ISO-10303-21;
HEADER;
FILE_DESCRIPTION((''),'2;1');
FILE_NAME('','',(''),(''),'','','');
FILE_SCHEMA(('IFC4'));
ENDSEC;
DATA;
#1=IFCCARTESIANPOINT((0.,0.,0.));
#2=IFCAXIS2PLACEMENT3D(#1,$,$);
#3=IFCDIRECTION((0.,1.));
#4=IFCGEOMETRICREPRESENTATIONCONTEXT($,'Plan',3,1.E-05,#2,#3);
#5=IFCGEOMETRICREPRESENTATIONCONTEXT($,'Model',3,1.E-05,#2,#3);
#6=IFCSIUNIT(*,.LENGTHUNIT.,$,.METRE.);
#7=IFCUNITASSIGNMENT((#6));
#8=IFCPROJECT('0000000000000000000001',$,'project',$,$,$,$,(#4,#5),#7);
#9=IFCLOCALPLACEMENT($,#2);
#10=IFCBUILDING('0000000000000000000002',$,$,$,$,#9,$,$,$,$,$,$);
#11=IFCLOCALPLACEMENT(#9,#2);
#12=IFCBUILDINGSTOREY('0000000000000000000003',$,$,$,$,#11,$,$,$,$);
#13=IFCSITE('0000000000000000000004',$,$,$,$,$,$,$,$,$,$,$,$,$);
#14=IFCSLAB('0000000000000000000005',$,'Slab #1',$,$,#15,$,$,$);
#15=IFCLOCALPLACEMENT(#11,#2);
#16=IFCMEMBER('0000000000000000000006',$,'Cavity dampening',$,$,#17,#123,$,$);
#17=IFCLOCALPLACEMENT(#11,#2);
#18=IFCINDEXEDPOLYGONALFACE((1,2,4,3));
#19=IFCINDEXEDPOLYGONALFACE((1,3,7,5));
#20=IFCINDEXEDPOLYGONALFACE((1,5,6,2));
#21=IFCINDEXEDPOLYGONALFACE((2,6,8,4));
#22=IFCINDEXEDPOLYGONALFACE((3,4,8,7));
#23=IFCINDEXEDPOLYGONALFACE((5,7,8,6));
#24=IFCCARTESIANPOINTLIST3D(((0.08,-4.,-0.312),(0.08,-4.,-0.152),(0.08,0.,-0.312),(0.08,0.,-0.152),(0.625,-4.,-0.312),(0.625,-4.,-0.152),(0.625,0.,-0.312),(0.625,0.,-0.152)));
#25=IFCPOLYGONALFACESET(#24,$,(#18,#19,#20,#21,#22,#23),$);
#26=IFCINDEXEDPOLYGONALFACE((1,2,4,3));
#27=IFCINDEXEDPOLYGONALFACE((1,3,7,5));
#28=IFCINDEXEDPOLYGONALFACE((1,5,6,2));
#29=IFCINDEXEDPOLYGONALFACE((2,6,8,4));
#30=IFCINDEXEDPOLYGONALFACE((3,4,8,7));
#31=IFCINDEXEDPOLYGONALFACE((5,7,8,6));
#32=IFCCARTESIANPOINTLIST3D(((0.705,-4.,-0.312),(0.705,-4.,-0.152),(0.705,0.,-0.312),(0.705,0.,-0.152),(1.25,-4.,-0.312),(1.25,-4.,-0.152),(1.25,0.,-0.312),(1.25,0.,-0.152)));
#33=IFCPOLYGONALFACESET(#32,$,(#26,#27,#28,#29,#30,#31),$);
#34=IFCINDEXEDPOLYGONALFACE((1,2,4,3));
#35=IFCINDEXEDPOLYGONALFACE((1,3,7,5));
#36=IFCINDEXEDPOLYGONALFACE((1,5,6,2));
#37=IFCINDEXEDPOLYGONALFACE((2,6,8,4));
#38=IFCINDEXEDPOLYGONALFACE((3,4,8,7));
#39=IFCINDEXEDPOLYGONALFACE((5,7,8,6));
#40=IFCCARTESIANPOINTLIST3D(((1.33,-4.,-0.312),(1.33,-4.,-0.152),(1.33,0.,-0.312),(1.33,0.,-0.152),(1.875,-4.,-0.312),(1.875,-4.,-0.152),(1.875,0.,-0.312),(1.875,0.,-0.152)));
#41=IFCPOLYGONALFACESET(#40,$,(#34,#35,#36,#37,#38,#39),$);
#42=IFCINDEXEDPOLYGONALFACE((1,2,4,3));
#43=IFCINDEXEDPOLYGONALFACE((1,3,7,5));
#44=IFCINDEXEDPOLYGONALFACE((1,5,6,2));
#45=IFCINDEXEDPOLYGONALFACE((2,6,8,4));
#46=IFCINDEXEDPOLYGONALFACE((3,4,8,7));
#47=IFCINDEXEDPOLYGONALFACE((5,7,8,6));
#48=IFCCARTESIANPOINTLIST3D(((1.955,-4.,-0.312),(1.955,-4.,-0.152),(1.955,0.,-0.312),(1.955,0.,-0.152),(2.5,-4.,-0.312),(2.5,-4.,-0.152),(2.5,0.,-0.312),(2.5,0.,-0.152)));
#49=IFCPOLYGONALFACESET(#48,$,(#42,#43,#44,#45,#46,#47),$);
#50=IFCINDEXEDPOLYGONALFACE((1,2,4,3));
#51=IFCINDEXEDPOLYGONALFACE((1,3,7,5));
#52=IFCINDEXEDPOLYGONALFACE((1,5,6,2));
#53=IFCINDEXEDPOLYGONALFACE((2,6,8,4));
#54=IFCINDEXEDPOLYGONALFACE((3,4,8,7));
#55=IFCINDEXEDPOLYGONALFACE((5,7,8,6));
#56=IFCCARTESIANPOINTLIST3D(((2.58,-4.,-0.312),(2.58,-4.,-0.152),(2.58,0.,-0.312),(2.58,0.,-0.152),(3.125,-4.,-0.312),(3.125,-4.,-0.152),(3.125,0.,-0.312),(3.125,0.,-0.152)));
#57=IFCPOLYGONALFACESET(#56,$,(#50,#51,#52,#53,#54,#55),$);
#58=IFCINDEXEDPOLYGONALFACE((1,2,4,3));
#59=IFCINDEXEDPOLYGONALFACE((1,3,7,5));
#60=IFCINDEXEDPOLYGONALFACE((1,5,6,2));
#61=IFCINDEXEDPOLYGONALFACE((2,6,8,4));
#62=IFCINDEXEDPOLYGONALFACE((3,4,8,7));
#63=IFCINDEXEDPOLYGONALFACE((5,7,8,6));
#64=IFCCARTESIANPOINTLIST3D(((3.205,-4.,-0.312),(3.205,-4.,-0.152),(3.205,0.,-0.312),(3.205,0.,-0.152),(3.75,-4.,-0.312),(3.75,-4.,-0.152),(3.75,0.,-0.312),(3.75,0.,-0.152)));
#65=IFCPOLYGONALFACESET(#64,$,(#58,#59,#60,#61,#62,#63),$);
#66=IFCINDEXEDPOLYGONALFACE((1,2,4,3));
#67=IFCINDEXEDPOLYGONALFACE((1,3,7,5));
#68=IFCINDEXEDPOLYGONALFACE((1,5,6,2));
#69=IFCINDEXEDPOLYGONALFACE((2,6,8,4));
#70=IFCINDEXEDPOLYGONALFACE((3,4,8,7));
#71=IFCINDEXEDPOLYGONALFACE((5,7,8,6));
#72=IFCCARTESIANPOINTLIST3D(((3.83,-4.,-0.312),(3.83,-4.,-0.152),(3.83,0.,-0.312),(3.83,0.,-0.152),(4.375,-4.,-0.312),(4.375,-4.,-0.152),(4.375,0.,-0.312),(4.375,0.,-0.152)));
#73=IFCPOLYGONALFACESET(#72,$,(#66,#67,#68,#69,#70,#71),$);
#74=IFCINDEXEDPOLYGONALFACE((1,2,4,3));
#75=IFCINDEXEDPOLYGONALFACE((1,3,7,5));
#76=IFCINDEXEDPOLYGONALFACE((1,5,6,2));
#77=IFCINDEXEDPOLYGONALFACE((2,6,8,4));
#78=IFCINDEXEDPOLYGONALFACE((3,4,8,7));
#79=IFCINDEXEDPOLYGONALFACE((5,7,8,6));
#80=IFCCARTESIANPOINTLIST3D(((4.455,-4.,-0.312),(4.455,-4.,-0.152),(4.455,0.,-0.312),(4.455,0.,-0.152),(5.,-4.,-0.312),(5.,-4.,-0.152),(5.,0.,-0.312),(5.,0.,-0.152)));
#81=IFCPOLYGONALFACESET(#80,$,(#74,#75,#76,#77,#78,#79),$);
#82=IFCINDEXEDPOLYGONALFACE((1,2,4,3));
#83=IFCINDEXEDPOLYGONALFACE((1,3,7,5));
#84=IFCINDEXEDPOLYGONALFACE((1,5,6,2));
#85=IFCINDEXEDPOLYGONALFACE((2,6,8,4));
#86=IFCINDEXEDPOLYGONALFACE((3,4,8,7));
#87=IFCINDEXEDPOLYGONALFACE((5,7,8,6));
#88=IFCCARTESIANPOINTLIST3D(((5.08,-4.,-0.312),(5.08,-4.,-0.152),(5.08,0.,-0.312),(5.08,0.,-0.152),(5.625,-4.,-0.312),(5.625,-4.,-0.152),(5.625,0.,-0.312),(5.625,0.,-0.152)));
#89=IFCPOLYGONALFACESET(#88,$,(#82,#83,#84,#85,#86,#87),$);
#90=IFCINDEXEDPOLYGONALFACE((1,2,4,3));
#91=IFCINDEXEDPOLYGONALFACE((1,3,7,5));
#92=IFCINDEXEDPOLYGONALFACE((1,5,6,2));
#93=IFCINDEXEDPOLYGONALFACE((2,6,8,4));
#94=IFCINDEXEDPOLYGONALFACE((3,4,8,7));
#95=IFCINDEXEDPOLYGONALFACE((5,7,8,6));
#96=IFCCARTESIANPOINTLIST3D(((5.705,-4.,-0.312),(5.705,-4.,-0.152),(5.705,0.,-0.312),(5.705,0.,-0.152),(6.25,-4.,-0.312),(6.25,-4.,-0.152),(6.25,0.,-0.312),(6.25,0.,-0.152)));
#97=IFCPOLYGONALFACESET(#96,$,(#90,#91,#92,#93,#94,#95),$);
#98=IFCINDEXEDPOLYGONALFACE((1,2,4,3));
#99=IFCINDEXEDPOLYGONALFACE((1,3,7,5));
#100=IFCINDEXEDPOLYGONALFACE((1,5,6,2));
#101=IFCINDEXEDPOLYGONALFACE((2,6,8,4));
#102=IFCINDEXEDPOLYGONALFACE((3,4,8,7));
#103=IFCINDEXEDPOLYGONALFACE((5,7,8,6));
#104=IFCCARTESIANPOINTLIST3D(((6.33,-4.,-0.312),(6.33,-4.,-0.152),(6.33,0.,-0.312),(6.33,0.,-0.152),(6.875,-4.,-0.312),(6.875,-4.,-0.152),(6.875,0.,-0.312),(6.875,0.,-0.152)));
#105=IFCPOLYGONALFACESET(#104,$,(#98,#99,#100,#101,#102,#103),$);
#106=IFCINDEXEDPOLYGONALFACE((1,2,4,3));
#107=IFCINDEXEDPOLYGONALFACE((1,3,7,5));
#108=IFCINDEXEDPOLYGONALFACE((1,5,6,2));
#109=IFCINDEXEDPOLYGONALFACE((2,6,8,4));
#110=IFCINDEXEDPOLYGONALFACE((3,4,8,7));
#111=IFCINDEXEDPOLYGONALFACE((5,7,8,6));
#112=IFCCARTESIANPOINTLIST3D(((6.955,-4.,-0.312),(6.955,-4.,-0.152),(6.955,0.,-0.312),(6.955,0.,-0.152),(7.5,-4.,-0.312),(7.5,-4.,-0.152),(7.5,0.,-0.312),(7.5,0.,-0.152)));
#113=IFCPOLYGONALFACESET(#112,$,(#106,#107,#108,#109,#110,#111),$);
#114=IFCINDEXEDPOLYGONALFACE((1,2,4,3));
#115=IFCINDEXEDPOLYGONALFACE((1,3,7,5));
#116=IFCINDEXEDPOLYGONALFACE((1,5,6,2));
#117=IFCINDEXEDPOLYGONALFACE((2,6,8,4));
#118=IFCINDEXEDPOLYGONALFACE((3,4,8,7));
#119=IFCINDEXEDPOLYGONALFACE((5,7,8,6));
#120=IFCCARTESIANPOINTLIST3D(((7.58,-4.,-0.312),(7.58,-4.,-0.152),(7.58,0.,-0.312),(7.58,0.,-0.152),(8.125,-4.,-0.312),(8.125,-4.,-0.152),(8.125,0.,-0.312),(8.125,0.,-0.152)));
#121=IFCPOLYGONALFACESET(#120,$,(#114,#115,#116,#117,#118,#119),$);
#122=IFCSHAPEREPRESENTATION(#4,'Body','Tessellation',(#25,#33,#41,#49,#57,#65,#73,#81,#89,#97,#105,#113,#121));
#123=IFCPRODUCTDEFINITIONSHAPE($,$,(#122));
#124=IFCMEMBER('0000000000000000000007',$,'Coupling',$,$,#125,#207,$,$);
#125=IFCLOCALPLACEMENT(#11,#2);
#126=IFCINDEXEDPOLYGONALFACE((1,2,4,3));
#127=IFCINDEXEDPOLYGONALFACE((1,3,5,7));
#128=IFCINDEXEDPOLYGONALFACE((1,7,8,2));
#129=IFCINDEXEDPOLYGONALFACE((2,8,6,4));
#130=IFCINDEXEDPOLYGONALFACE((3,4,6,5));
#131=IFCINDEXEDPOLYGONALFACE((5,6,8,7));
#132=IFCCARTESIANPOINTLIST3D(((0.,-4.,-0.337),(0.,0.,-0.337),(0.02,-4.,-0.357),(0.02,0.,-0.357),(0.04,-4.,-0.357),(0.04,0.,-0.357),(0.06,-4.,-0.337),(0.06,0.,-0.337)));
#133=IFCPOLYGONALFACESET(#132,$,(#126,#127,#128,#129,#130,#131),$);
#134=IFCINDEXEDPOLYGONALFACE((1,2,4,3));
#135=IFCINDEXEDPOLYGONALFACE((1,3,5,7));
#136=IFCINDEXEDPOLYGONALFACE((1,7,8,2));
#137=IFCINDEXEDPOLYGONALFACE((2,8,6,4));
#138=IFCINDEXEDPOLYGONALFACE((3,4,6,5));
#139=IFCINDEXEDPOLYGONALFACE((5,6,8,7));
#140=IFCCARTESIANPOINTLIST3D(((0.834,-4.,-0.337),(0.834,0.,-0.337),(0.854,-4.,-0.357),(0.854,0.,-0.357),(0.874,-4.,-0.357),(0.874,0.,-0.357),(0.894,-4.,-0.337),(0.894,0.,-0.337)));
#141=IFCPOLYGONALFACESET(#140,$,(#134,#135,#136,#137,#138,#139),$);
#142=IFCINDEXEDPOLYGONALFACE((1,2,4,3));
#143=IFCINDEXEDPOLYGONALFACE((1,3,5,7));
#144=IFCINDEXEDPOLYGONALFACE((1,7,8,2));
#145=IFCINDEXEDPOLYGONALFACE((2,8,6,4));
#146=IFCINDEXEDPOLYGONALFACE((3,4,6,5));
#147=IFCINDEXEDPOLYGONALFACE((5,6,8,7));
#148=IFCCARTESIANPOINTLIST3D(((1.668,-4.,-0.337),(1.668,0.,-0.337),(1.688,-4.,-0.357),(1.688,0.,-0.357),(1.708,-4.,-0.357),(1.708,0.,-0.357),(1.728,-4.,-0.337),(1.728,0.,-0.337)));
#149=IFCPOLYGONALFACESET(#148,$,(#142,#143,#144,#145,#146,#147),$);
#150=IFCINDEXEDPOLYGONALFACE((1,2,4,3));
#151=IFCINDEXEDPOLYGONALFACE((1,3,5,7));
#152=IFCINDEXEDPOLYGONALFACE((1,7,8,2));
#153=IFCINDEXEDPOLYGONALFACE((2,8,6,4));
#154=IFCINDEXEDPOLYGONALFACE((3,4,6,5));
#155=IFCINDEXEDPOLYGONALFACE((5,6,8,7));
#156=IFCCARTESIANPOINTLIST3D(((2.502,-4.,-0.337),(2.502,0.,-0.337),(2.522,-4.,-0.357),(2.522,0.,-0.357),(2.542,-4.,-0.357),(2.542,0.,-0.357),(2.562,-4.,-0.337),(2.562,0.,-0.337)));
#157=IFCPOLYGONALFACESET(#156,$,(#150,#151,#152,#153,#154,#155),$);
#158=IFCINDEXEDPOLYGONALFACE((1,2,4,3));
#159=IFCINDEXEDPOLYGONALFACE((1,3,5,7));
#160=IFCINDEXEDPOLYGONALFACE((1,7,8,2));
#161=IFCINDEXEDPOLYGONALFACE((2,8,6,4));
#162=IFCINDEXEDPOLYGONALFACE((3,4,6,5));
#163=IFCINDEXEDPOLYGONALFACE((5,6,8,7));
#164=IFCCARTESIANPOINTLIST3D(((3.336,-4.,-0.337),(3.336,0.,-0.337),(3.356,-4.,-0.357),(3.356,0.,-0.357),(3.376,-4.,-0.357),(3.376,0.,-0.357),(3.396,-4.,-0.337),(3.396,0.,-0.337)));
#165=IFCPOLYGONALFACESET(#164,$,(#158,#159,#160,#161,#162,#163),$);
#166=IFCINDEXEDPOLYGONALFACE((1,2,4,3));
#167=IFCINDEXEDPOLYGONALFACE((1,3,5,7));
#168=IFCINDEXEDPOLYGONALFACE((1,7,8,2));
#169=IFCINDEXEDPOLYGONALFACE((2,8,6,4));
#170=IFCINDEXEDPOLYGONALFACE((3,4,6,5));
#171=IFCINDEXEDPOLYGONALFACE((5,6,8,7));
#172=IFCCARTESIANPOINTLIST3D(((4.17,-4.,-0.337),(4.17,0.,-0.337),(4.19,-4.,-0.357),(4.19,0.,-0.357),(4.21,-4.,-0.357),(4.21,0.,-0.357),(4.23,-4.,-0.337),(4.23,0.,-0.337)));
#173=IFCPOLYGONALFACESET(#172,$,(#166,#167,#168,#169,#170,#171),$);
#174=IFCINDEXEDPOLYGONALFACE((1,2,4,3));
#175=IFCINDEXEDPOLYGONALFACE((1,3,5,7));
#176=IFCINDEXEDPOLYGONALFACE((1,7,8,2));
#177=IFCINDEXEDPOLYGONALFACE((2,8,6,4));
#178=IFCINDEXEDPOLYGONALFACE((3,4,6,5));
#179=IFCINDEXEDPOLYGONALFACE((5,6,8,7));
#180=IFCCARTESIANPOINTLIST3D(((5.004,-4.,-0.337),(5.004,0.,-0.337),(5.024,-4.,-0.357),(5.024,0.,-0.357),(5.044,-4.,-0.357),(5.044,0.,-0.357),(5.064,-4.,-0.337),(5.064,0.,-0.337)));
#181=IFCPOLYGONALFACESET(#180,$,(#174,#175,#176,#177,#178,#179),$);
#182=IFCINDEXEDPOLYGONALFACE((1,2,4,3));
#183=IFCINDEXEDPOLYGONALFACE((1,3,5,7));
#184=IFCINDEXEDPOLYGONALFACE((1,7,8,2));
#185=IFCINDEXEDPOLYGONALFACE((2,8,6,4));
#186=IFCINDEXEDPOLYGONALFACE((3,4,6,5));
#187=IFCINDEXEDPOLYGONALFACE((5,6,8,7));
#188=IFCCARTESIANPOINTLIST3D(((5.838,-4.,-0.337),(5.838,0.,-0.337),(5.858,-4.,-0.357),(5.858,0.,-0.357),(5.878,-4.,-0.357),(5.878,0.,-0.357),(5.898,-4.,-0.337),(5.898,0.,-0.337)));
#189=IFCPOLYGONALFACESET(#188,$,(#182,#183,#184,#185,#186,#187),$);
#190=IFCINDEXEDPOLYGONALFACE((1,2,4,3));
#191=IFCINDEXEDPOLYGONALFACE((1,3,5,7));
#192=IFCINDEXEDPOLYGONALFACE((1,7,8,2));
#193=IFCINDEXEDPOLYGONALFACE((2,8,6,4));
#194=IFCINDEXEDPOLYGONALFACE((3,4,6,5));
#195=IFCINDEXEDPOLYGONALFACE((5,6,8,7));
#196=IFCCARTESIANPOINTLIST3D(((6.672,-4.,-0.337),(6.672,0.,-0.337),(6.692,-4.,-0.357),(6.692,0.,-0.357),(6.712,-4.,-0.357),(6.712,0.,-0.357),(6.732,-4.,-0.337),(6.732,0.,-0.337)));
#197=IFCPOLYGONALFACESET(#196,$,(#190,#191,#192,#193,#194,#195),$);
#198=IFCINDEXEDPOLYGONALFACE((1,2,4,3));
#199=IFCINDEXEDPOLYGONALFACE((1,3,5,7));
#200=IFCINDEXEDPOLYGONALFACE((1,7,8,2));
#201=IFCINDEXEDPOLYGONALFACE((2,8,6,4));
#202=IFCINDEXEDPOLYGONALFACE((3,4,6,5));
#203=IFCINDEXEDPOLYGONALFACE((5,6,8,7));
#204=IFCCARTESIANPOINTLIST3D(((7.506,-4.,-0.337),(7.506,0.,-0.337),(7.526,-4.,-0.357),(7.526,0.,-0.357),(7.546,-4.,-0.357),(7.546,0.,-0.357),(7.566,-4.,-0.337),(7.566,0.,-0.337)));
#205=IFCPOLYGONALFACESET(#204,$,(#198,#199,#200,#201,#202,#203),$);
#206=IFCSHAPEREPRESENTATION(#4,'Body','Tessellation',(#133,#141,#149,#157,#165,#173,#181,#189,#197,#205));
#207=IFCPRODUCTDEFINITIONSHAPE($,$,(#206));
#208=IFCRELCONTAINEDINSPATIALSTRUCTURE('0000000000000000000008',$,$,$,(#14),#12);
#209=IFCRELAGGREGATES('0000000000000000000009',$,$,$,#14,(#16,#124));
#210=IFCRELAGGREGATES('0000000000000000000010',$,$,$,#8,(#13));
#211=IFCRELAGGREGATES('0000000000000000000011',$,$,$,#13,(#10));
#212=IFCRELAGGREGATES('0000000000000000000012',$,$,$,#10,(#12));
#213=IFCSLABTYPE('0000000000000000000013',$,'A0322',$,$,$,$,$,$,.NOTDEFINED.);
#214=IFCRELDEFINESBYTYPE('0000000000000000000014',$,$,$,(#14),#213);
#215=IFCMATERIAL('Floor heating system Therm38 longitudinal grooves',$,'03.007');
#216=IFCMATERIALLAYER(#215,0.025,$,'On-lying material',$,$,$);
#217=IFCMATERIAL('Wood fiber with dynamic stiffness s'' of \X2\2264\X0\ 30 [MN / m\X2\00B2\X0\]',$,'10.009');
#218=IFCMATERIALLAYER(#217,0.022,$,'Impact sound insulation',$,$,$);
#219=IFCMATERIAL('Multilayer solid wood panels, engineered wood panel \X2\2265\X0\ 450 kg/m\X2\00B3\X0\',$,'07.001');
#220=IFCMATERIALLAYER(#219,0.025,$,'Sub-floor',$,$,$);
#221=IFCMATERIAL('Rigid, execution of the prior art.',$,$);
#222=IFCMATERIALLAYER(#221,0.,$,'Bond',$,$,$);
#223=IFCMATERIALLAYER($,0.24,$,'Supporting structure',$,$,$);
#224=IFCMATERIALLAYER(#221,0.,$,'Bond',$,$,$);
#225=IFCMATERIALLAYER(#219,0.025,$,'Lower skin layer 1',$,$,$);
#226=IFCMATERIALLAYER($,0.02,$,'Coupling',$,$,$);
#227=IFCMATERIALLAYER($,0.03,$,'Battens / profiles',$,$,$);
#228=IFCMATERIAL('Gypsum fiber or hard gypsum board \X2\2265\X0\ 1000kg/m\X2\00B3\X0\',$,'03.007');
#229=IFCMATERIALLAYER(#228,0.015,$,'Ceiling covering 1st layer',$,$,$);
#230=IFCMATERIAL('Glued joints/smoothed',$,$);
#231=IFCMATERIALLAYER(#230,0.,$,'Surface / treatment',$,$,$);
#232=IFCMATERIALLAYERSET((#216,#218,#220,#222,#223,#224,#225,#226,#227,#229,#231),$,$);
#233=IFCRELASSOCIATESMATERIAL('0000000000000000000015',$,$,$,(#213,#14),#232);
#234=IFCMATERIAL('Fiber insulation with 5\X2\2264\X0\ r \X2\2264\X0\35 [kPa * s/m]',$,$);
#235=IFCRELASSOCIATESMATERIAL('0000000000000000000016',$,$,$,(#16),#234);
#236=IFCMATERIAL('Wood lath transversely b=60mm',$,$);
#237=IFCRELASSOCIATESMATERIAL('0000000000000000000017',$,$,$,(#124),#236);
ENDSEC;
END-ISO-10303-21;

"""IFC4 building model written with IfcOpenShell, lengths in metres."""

from ifc_helpers import new_model, si_unit, direction, frame, frame_2d, origin, place, context, project, spatial, polyline, rectangle, outline, extrude, material, layer, layer_set, type_object, element, aggregate, save


model = new_model("IFC4")

# Units and contexts
plan_context = context("Plan", 3, precision=1e-05, world=origin(), true_north=direction((0.0, 1.0)))
model_context = context("Model", 3, precision=1e-05, world=origin(), true_north=direction((0.0, 1.0)))
ifc_project = project(units=[si_unit("LENGTHUNIT", "METRE")], contexts=[plan_context, model_context])

# Site, building, storey
site = spatial("IfcSite", under=ifc_project)
building_placement = place(None, origin())
building = spatial("IfcBuilding", under=site, at=building_placement)
storey_placement = place(building_placement, origin())
storey = spatial("IfcBuildingStorey", under=building, at=storey_placement)

# Slab, members
ifc_material_1 = material(Name="Floor heating system Therm38 longitudinal grooves", Category="03.007")
ifc_layer_1 = layer(ifc_material_1, 0.025, Name="On-lying material")
ifc_material_2 = material(Name="Wood fiber with dynamic stiffness s' of ≤ 30 [MN / m²]", Category="10.009")
ifc_layer_2 = layer(ifc_material_2, 0.022, Name="Impact sound insulation")
ifc_material_3 = material(Name="Multilayer solid wood panels, engineered wood panel ≥ 450 kg/m³", Category="07.001")
ifc_layer_3 = layer(ifc_material_3, 0.025, Name="Sub-floor")
ifc_material_4 = material(Name="Rigid, execution of the prior art.")
ifc_layer_4 = layer(ifc_material_4, 0.0, Name="Bond")
ifc_layer_5 = layer(None, 0.24, Name="Supporting structure")
ifc_layer_6 = layer(ifc_material_4, 0.0, Name="Bond")
ifc_layer_7 = layer(ifc_material_3, 0.025, Name="Lower skin layer 1")
ifc_layer_8 = layer(None, 0.02, Name="Coupling")
ifc_layer_9 = layer(None, 0.03, Name="Battens / profiles")
ifc_material_5 = material(Name="Gypsum fiber or hard gypsum board ≥ 1000kg/m³", Category="03.007")
ifc_layer_10 = layer(ifc_material_5, 0.015, Name="Ceiling covering 1st layer")
ifc_material_6 = material(Name="Glued joints/smoothed")
ifc_layer_11 = layer(ifc_material_6, 0.0, Name="Surface / treatment")
ifc_layer_set = layer_set([ifc_layer_1, ifc_layer_2, ifc_layer_3, ifc_layer_4, ifc_layer_5, ifc_layer_6, ifc_layer_7, ifc_layer_8, ifc_layer_9, ifc_layer_10, ifc_layer_11])
slab_type = type_object("IfcSlabType", Name="A0322", PredefinedType="NOTDEFINED", material=ifc_layer_set)
slab_placement = place(None, frame((0.0, 0.0, 0.0), z_axis=(0.0, 0.0, -1.0), x_axis=(1.0, 0.0, 0.0)))
slab = element("IfcSlab", 1, at=slab_placement, inside=storey, type_object=slab_type, material=ifc_layer_set, Name="Slab #1")
ifc_material_7 = material(Name="Fiber insulation with 5≤ r ≤35 [kPa * s/m]")
member_1_placement = place(slab_placement, origin())
member_1 = element("IfcMember", 2, at=member_1_placement, material=ifc_material_7, Name="Cavity dampening", context=plan_context, shape_type="SweptSolid", body=[
    extrude(rectangle(XDim=0.545, YDim=0.16, at=frame_2d((0.2725, 0.08), x_axis=(1.0, 0.0))), frame((0.08, 4.0, 0.152), z_axis=(0.0, -1.0, 0.0), x_axis=(1.0, 0.0, 0.0)), (0.0, 0.0, 1.0), 4.0),
    extrude(rectangle(XDim=0.545, YDim=0.16, at=frame_2d((0.2725, 0.08), x_axis=(1.0, 0.0))), frame((0.705, 4.0, 0.152), z_axis=(0.0, -1.0, 0.0), x_axis=(1.0, 0.0, 0.0)), (0.0, 0.0, 1.0), 4.0),
    extrude(rectangle(XDim=0.545, YDim=0.16, at=frame_2d((0.2725, 0.08), x_axis=(1.0, 0.0))), frame((1.33, 4.0, 0.152), z_axis=(0.0, -1.0, 0.0), x_axis=(1.0, 0.0, 0.0)), (0.0, 0.0, 1.0), 4.0),
    extrude(rectangle(XDim=0.545, YDim=0.16, at=frame_2d((0.2725, 0.08), x_axis=(1.0, 0.0))), frame((1.955, 4.0, 0.152), z_axis=(0.0, -1.0, 0.0), x_axis=(1.0, 0.0, 0.0)), (0.0, 0.0, 1.0), 4.0),
    extrude(rectangle(XDim=0.545, YDim=0.16, at=frame_2d((0.2725, 0.08), x_axis=(1.0, 0.0))), frame((2.58, 4.0, 0.152), z_axis=(0.0, -1.0, 0.0), x_axis=(1.0, 0.0, 0.0)), (0.0, 0.0, 1.0), 4.0),
    extrude(rectangle(XDim=0.545, YDim=0.16, at=frame_2d((0.2725, 0.08), x_axis=(1.0, 0.0))), frame((3.205, 4.0, 0.152), z_axis=(0.0, -1.0, 0.0), x_axis=(1.0, 0.0, 0.0)), (0.0, 0.0, 1.0), 4.0),
    extrude(rectangle(XDim=0.545, YDim=0.16, at=frame_2d((0.2725, 0.08), x_axis=(1.0, 0.0))), frame((3.83, 4.0, 0.152), z_axis=(0.0, -1.0, 0.0), x_axis=(1.0, 0.0, 0.0)), (0.0, 0.0, 1.0), 4.0),
    extrude(rectangle(XDim=0.545, YDim=0.16, at=frame_2d((0.2725, 0.08), x_axis=(1.0, 0.0))), frame((4.455, 4.0, 0.152), z_axis=(0.0, -1.0, 0.0), x_axis=(1.0, 0.0, 0.0)), (0.0, 0.0, 1.0), 4.0),
    extrude(rectangle(XDim=0.545, YDim=0.16, at=frame_2d((0.2725, 0.08), x_axis=(1.0, 0.0))), frame((5.08, 4.0, 0.152), z_axis=(0.0, -1.0, 0.0), x_axis=(1.0, 0.0, 0.0)), (0.0, 0.0, 1.0), 4.0),
    extrude(rectangle(XDim=0.545, YDim=0.16, at=frame_2d((0.2725, 0.08), x_axis=(1.0, 0.0))), frame((5.705, 4.0, 0.152), z_axis=(0.0, -1.0, 0.0), x_axis=(1.0, 0.0, 0.0)), (0.0, 0.0, 1.0), 4.0),
    extrude(rectangle(XDim=0.545, YDim=0.16, at=frame_2d((0.2725, 0.08), x_axis=(1.0, 0.0))), frame((6.33, 4.0, 0.152), z_axis=(0.0, -1.0, 0.0), x_axis=(1.0, 0.0, 0.0)), (0.0, 0.0, 1.0), 4.0),
    extrude(rectangle(XDim=0.545, YDim=0.16, at=frame_2d((0.2725, 0.08), x_axis=(1.0, 0.0))), frame((6.955, 4.0, 0.152), z_axis=(0.0, -1.0, 0.0), x_axis=(1.0, 0.0, 0.0)), (0.0, 0.0, 1.0), 4.0),
    extrude(rectangle(XDim=0.545, YDim=0.16, at=frame_2d((0.2725, 0.08), x_axis=(1.0, 0.0))), frame((7.58, 4.0, 0.152), z_axis=(0.0, -1.0, 0.0), x_axis=(1.0, 0.0, 0.0)), (0.0, 0.0, 1.0), 4.0),
])
ifc_material_8 = material(Name="Wood lath transversely b=60mm")
member_2_placement = place(slab_placement, origin())
member_2 = element("IfcMember", 3, at=member_2_placement, material=ifc_material_8, Name="Coupling", context=plan_context, shape_type="SweptSolid", body=[
    extrude(outline(polyline([(0.0, 0.0), (0.06, 0.0), (0.04, 0.02), (0.02, 0.02), (0.0, 0.0)])), frame((0.0, 4.0, 0.337), z_axis=(0.0, -1.0, 0.0), x_axis=(1.0, 0.0, 0.0)), (0.0, 0.0, 1.0), 4.0),
    extrude(outline(polyline([(0.0, 0.0), (0.06, 0.0), (0.04, 0.02), (0.02, 0.02), (0.0, 0.0)])), frame((0.834, 4.0, 0.337), z_axis=(0.0, -1.0, 0.0), x_axis=(1.0, 0.0, 0.0)), (0.0, 0.0, 1.0), 4.0),
    extrude(outline(polyline([(0.0, 0.0), (0.06, 0.0), (0.04, 0.02), (0.02, 0.02), (0.0, 0.0)])), frame((1.668, 4.0, 0.337), z_axis=(0.0, -1.0, 0.0), x_axis=(1.0, 0.0, 0.0)), (0.0, 0.0, 1.0), 4.0),
    extrude(outline(polyline([(0.0, 0.0), (0.06, 0.0), (0.04, 0.02), (0.02, 0.02), (0.0, 0.0)])), frame((2.502, 4.0, 0.337), z_axis=(0.0, -1.0, 0.0), x_axis=(1.0, 0.0, 0.0)), (0.0, 0.0, 1.0), 4.0),
    extrude(outline(polyline([(0.0, 0.0), (0.06, 0.0), (0.04, 0.02), (0.02, 0.02), (0.0, 0.0)])), frame((3.336, 4.0, 0.337), z_axis=(0.0, -1.0, 0.0), x_axis=(1.0, 0.0, 0.0)), (0.0, 0.0, 1.0), 4.0),
    extrude(outline(polyline([(0.0, 0.0), (0.06, 0.0), (0.04, 0.02), (0.02, 0.02), (0.0, 0.0)])), frame((4.17, 4.0, 0.337), z_axis=(0.0, -1.0, 0.0), x_axis=(1.0, 0.0, 0.0)), (0.0, 0.0, 1.0), 4.0),
    extrude(outline(polyline([(0.0, 0.0), (0.06, 0.0), (0.04, 0.02), (0.02, 0.02), (0.0, 0.0)])), frame((5.004, 4.0, 0.337), z_axis=(0.0, -1.0, 0.0), x_axis=(1.0, 0.0, 0.0)), (0.0, 0.0, 1.0), 4.0),
    extrude(outline(polyline([(0.0, 0.0), (0.06, 0.0), (0.04, 0.02), (0.02, 0.02), (0.0, 0.0)])), frame((5.838, 4.0, 0.337), z_axis=(0.0, -1.0, 0.0), x_axis=(1.0, 0.0, 0.0)), (0.0, 0.0, 1.0), 4.0),
    extrude(outline(polyline([(0.0, 0.0), (0.06, 0.0), (0.04, 0.02), (0.02, 0.02), (0.0, 0.0)])), frame((6.672, 4.0, 0.337), z_axis=(0.0, -1.0, 0.0), x_axis=(1.0, 0.0, 0.0)), (0.0, 0.0, 1.0), 4.0),
    extrude(outline(polyline([(0.0, 0.0), (0.06, 0.0), (0.04, 0.02), (0.02, 0.02), (0.0, 0.0)])), frame((7.506, 4.0, 0.337), z_axis=(0.0, -1.0, 0.0), x_axis=(1.0, 0.0, 0.0)), (0.0, 0.0, 1.0), 4.0),
])
aggregate(slab, [member_1, member_2])

save(model, "model.ifc")
